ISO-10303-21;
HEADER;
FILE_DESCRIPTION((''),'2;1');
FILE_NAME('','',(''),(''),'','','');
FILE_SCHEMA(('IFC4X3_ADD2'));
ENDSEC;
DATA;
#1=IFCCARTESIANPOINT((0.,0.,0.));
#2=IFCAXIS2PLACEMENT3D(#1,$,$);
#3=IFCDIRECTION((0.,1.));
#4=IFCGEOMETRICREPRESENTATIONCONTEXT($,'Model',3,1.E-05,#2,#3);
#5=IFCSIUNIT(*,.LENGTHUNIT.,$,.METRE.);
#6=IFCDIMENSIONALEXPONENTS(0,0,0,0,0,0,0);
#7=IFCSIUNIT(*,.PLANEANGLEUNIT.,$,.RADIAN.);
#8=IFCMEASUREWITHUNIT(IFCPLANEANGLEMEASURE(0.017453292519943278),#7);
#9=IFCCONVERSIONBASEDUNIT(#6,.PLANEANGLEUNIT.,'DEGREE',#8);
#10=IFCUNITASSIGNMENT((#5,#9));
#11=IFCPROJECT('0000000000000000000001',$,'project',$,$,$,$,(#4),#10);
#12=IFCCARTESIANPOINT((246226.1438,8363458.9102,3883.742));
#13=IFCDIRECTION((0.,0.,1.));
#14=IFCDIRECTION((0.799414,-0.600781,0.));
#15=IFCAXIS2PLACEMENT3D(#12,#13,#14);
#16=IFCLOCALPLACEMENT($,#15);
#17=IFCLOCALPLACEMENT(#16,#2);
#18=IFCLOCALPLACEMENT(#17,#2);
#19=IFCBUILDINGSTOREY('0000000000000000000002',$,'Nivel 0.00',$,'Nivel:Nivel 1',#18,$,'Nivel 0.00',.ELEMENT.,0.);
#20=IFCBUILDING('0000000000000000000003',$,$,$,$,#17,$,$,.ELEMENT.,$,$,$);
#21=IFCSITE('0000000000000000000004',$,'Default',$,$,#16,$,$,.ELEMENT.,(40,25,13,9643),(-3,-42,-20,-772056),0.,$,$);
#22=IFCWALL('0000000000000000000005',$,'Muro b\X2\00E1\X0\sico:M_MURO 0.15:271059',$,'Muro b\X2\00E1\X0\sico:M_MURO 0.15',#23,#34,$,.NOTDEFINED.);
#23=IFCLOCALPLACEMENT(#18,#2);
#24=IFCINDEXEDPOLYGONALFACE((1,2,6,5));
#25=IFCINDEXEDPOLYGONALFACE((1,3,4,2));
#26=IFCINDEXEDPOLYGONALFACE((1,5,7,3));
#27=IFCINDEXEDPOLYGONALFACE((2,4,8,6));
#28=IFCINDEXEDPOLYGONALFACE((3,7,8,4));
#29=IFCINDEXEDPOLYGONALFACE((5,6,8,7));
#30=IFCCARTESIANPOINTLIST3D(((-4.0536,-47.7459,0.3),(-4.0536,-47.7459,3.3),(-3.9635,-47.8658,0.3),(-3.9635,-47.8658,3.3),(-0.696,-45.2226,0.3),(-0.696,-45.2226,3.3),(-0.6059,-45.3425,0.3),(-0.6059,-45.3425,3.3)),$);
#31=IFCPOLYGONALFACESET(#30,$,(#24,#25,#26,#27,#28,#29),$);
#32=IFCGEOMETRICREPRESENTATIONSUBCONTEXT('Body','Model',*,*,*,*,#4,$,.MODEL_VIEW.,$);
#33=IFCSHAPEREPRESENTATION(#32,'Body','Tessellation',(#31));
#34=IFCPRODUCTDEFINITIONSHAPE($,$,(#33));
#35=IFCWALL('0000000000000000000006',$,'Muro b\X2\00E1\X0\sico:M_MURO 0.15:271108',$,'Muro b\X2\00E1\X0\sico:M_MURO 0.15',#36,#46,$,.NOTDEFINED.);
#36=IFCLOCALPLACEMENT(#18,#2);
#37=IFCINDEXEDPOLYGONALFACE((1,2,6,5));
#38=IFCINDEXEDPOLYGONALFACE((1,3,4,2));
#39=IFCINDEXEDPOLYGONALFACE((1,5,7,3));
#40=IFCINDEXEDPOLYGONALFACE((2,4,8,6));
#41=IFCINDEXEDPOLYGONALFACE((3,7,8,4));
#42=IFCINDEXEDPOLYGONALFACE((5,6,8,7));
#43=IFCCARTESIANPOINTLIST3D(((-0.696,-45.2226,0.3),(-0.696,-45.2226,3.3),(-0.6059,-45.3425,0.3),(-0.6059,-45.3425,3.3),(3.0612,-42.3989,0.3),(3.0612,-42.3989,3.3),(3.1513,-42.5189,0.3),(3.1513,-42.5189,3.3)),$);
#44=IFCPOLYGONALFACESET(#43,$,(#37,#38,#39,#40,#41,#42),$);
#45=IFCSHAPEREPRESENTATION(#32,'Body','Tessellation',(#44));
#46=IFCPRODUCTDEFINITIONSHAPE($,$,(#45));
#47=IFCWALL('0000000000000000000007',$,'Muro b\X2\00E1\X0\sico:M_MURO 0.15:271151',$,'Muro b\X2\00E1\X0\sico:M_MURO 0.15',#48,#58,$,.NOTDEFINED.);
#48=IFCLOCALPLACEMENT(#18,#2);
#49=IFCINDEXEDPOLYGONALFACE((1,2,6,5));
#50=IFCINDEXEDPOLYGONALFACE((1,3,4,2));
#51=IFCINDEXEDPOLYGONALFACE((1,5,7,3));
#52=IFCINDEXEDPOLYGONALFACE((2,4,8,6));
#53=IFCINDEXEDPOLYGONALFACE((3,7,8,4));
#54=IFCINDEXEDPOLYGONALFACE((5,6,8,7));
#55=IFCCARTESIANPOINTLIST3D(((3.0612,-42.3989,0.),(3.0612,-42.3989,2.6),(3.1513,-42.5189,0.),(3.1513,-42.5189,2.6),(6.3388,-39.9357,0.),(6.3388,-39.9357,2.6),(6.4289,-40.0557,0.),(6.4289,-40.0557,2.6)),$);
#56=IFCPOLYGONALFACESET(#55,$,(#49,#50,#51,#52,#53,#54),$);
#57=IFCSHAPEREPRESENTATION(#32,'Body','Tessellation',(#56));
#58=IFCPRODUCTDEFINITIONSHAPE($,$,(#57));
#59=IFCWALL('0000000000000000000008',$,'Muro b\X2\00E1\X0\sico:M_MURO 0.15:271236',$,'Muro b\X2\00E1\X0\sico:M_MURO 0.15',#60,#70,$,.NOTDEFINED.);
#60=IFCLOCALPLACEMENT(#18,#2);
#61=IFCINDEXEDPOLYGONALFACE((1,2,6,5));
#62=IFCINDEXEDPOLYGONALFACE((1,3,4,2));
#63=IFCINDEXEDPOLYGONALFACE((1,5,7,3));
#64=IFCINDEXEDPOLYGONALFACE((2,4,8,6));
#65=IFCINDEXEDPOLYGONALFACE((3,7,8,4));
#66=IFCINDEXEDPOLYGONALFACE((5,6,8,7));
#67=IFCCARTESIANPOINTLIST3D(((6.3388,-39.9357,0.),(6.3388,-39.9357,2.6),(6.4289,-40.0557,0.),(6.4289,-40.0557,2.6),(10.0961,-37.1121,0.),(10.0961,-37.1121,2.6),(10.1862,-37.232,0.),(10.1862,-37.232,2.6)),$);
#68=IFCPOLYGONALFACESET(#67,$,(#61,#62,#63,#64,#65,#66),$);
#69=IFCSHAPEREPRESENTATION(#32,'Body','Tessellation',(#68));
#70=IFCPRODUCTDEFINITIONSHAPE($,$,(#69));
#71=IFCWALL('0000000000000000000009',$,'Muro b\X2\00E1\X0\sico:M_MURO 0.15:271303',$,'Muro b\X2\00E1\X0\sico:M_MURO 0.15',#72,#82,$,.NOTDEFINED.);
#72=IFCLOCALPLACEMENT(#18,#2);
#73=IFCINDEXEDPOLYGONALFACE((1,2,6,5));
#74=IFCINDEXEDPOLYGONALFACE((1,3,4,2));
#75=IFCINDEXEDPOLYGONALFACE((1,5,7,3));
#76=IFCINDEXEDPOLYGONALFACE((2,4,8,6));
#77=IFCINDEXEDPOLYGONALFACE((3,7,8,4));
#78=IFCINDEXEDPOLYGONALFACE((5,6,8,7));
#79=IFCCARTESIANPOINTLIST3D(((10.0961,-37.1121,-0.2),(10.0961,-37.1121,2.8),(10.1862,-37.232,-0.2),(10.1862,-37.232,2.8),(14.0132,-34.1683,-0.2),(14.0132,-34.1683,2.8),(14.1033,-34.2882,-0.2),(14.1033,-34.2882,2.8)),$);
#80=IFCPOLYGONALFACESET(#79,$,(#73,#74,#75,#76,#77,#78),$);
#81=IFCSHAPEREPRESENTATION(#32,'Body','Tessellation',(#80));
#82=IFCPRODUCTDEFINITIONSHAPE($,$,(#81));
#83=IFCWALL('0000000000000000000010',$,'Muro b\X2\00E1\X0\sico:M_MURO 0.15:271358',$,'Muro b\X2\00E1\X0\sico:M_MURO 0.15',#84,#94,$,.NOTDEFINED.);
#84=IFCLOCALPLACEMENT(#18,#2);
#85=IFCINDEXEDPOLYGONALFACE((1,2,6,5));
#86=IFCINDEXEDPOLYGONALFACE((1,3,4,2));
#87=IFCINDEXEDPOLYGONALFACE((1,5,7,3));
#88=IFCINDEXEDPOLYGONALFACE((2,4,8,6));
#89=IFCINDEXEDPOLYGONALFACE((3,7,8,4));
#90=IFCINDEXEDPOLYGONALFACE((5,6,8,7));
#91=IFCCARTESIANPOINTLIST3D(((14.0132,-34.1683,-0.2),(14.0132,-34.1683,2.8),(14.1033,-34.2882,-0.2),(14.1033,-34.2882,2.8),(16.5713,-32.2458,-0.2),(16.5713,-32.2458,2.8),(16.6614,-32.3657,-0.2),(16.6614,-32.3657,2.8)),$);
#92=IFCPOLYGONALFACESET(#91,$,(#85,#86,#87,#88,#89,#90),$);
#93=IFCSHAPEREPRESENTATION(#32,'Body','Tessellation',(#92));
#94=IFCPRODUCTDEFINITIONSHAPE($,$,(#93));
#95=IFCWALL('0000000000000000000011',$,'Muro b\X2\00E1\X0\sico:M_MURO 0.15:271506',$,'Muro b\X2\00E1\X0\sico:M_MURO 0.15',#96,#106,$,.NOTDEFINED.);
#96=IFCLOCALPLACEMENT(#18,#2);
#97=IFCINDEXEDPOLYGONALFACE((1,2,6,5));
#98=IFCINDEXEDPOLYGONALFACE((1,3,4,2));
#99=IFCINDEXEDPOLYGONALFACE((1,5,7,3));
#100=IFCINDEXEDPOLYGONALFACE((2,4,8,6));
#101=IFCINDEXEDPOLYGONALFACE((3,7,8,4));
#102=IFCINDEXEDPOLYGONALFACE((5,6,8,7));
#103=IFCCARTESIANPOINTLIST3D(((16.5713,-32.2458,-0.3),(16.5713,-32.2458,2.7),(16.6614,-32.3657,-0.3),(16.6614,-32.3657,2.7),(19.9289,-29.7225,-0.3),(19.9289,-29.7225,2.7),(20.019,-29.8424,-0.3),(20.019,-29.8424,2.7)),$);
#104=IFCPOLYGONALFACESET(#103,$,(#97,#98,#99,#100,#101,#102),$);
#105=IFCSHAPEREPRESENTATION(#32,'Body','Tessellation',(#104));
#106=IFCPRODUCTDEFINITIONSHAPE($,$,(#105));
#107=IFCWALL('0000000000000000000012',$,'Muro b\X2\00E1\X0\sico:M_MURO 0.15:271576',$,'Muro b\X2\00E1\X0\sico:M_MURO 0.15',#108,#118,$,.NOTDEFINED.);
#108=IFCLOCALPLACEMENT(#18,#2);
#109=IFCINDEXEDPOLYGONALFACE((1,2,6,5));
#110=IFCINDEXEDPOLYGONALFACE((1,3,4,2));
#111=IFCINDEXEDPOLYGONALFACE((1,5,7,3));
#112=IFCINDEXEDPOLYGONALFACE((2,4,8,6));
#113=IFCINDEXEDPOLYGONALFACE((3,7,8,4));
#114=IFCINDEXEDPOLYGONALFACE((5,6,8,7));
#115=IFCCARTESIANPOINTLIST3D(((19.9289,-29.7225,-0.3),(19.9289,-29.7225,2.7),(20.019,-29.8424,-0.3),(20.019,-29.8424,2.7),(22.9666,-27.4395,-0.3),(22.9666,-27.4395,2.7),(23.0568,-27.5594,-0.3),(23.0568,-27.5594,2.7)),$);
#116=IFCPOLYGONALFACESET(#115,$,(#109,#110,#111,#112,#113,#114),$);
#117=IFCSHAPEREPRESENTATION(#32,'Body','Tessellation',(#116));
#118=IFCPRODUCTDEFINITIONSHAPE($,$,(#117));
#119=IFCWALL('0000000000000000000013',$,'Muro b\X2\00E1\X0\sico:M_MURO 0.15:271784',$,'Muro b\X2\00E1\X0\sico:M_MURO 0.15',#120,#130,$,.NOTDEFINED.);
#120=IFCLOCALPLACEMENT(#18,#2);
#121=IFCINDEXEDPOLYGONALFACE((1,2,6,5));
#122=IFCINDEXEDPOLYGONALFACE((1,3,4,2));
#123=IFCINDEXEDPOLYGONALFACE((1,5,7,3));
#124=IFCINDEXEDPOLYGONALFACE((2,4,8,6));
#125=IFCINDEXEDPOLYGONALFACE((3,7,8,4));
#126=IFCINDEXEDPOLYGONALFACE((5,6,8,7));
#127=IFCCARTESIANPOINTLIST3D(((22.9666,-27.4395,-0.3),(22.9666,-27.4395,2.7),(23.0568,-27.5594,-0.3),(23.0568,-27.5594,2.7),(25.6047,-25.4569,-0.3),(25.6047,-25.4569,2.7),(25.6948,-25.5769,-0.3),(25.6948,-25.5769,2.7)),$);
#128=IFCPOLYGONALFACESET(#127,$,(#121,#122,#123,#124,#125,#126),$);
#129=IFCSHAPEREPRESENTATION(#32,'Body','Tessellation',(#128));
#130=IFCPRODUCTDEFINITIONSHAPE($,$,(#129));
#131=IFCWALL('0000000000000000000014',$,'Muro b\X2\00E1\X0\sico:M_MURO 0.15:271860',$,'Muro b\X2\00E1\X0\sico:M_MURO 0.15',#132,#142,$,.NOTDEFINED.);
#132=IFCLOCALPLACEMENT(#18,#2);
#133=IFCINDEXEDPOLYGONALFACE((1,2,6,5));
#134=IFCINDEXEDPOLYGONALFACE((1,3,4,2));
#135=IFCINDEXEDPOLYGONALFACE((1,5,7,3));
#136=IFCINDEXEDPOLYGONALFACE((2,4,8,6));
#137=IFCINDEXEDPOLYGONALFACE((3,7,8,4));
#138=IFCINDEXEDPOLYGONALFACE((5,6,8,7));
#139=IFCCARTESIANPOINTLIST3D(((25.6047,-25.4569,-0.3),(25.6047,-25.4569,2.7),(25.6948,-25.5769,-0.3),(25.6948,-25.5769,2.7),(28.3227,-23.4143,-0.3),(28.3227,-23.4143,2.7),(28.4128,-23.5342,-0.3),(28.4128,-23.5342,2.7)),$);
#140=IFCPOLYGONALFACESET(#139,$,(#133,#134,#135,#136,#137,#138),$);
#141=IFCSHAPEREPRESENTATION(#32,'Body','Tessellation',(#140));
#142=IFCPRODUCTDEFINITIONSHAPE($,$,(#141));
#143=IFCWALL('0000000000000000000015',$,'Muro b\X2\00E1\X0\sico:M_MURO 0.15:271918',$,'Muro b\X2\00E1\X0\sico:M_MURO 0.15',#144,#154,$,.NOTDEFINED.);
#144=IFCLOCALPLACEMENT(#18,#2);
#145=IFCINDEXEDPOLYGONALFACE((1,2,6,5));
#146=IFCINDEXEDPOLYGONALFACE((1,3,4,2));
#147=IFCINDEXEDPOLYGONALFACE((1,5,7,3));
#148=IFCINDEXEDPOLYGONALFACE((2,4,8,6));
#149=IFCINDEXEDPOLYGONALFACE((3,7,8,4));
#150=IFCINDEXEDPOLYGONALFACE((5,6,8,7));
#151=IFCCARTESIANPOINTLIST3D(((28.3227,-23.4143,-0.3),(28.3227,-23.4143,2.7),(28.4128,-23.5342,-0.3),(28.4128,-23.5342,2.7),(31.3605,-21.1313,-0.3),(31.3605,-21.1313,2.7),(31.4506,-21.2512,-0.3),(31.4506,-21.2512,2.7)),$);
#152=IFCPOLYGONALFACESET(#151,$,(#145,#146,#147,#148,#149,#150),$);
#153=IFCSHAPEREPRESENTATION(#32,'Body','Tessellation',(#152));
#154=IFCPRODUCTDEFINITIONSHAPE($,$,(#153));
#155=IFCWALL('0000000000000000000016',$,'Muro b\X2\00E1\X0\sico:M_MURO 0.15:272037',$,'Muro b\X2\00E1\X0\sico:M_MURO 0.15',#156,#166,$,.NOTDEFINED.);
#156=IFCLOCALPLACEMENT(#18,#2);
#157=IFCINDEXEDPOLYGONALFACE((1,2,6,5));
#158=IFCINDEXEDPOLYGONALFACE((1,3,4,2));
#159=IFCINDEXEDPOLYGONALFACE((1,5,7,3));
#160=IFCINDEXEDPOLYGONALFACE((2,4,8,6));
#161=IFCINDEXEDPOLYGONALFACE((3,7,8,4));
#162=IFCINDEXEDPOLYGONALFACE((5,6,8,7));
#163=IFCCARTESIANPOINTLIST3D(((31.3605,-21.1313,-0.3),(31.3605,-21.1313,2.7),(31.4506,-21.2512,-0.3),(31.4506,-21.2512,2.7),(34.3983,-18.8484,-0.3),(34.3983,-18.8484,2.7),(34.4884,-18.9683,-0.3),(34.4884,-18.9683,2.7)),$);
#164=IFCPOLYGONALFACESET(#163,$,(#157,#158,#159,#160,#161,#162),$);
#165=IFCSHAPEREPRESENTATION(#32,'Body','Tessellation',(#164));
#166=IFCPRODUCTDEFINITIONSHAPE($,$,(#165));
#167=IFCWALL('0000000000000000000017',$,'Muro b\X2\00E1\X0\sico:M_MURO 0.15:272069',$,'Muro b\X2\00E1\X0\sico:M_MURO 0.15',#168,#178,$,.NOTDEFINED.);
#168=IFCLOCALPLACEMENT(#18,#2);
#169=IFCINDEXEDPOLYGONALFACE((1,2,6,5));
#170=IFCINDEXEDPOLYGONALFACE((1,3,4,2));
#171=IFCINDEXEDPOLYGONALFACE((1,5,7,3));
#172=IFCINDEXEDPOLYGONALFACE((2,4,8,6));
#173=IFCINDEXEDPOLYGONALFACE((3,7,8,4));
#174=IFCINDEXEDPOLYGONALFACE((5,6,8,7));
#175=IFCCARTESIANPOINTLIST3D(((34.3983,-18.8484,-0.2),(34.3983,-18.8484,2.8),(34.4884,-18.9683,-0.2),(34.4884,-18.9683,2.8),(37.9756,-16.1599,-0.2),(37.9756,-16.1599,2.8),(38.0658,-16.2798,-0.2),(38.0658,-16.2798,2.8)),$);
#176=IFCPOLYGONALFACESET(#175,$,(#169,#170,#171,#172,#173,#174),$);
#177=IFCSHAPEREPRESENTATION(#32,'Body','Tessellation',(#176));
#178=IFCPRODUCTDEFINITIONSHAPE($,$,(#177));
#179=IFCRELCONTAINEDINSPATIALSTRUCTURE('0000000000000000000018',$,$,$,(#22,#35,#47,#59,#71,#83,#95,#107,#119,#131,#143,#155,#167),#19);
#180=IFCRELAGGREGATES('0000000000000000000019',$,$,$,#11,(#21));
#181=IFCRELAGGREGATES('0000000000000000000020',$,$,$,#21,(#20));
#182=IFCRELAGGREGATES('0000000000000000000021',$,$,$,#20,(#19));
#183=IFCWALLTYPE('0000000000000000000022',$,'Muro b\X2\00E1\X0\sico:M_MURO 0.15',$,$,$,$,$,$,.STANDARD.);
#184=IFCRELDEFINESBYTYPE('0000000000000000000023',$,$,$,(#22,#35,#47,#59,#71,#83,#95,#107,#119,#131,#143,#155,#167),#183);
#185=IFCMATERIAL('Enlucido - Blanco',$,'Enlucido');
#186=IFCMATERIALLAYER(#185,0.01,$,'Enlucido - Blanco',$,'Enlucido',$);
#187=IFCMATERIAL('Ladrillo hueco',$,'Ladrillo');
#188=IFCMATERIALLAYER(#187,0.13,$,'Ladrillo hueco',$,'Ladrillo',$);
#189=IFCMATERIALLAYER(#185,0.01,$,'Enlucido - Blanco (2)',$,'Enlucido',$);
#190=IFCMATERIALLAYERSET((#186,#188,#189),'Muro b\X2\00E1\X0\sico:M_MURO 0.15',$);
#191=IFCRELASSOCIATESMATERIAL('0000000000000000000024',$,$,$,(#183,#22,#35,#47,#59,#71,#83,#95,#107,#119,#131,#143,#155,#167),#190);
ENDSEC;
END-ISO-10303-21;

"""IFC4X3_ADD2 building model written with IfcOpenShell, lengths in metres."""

from ifc_helpers import new_model, entity, si_unit, converted_unit, direction, frame, frame_2d, origin, place, context, subcontext, project, spatial, rectangle, extrude, material, layer, layer_set, type_object, element, save


model = new_model("IFC4X3_ADD2")

# Units and contexts
model_context = context("Model", 3, precision=1e-05, world=origin(), true_north=direction((0.0, 1.0)))
body_context = subcontext(model_context, "Body", "Model", "MODEL_VIEW")
ifc_project = project(units=[si_unit("LENGTHUNIT", "METRE"), converted_unit("PLANEANGLEUNIT", "DEGREE", entity("IfcPlaneAngleMeasure", 0.017453292519943278), si_unit("PLANEANGLEUNIT", "RADIAN"), dimensions=[0, 0, 0, 0, 0, 0, 0])], contexts=[model_context])

# Site, building, storey
site_placement = place(None, frame((246226.1438, 8363458.9102, 3883.742), z_axis=(0.0, 0.0, 1.0), x_axis=(0.799414, -0.600781, 0.0)))
site = spatial("IfcSite", under=ifc_project, at=site_placement, Name="Default", CompositionType="ELEMENT", RefLatitude=(40, 25, 13, 9643), RefLongitude=(-3, -42, -20, -772056), RefElevation=0.0)
building_placement = place(site_placement, origin())
building = spatial("IfcBuilding", under=site, at=building_placement, CompositionType="ELEMENT")
storey_placement = place(building_placement, origin())
storey = spatial("IfcBuildingStorey", under=building, at=storey_placement, Name="Nivel 0.00", ObjectType="Nivel:Nivel 1", LongName="Nivel 0.00", CompositionType="ELEMENT", Elevation=0.0)

# Walls
ifc_material_1 = material(Name="Enlucido - Blanco", Category="Enlucido")
ifc_layer_1 = layer(ifc_material_1, 0.01, Name="Enlucido - Blanco", Category="Enlucido")
ifc_material_2 = material(Name="Ladrillo hueco", Category="Ladrillo")
ifc_layer_2 = layer(ifc_material_2, 0.13, Name="Ladrillo hueco", Category="Ladrillo")
ifc_layer_3 = layer(ifc_material_1, 0.01, Name="Enlucido - Blanco (2)", Category="Enlucido")
ifc_layer_set_1 = layer_set([ifc_layer_1, ifc_layer_2, ifc_layer_3], Name="Muro básico:M_MURO 0.15")
wall_type = type_object("IfcWallType", Name="Muro básico:M_MURO 0.15", PredefinedType="STANDARD", material=ifc_layer_set_1)
wall_1_placement = place(storey_placement, frame((-0.651, -45.2826, 0.3), z_axis=(0.0, 0.0, 1.0), x_axis=(-0.799414, -0.60078, 0.0)))
element("IfcWall", 1, at=wall_1_placement, inside=storey, type_object=wall_type, material=ifc_layer_set_1, Name="Muro básico:M_MURO 0.15:271059", ObjectType="Muro básico:M_MURO 0.15", PredefinedType="NOTDEFINED", context=body_context, shape_type="SweptSolid", body=[
    extrude(rectangle(XDim=4.2, YDim=0.15, at=frame_2d((2.1, 0.0), x_axis=(-1.0, 0.0))), origin(), (0.0, 0.0, 1.0), 3.0),
])
wall_2_placement = place(storey_placement, frame((3.1063, -42.4589, 0.3), z_axis=(0.0, 0.0, 1.0), x_axis=(-0.799414, -0.60078, 0.0)))
element("IfcWall", 2, at=wall_2_placement, inside=storey, type_object=wall_type, material=ifc_layer_set_1, Name="Muro básico:M_MURO 0.15:271108", ObjectType="Muro básico:M_MURO 0.15", PredefinedType="NOTDEFINED", context=body_context, shape_type="SweptSolid", body=[
    extrude(rectangle(XDim=4.7, YDim=0.15, at=frame_2d((2.35, 0.0), x_axis=(-1.0, 0.0))), origin(), (0.0, 0.0, 1.0), 3.0),
])
wall_3_placement = place(storey_placement, frame((6.3839, -39.9957, 0.0), z_axis=(0.0, 0.0, 1.0), x_axis=(-0.799414, -0.60078, 0.0)))
element("IfcWall", 3, at=wall_3_placement, inside=storey, type_object=wall_type, material=ifc_layer_set_1, Name="Muro básico:M_MURO 0.15:271151", ObjectType="Muro básico:M_MURO 0.15", PredefinedType="NOTDEFINED", context=body_context, shape_type="SweptSolid", body=[
    extrude(rectangle(XDim=4.1, YDim=0.15, at=frame_2d((2.05, 0.0), x_axis=(-1.0, 0.0))), origin(), (0.0, 0.0, 1.0), 2.6),
])
wall_4_placement = place(storey_placement, frame((10.1411, -37.172, 0.0), z_axis=(0.0, 0.0, 1.0), x_axis=(-0.799414, -0.60078, 0.0)))
element("IfcWall", 4, at=wall_4_placement, inside=storey, type_object=wall_type, material=ifc_layer_set_1, Name="Muro básico:M_MURO 0.15:271236", ObjectType="Muro básico:M_MURO 0.15", PredefinedType="NOTDEFINED", context=body_context, shape_type="SweptSolid", body=[
    extrude(rectangle(XDim=4.7, YDim=0.15, at=frame_2d((2.35, 0.0), x_axis=(-1.0, 0.0))), origin(), (0.0, 0.0, 1.0), 2.6),
])
wall_5_placement = place(storey_placement, frame((14.0583, -34.2282, -0.2), z_axis=(0.0, 0.0, 1.0), x_axis=(-0.799414, -0.60078, 0.0)))
element("IfcWall", 5, at=wall_5_placement, inside=storey, type_object=wall_type, material=ifc_layer_set_1, Name="Muro básico:M_MURO 0.15:271303", ObjectType="Muro básico:M_MURO 0.15", PredefinedType="NOTDEFINED", context=body_context, shape_type="SweptSolid", body=[
    extrude(rectangle(XDim=4.9, YDim=0.15, at=frame_2d((2.45, 0.0), x_axis=(-1.0, 0.0))), origin(), (0.0, 0.0, 1.0), 3.0),
])
wall_6_placement = place(storey_placement, frame((16.6164, -32.3057, -0.2), z_axis=(0.0, 0.0, 1.0), x_axis=(-0.799414, -0.60078, 0.0)))
element("IfcWall", 6, at=wall_6_placement, inside=storey, type_object=wall_type, material=ifc_layer_set_1, Name="Muro básico:M_MURO 0.15:271358", ObjectType="Muro básico:M_MURO 0.15", PredefinedType="NOTDEFINED", context=body_context, shape_type="SweptSolid", body=[
    extrude(rectangle(XDim=3.2, YDim=0.15, at=frame_2d((1.6, 0.0), x_axis=(-1.0, 0.0))), origin(), (0.0, 0.0, 1.0), 3.0),
])
wall_7_placement = place(storey_placement, frame((19.9739, -29.7824, -0.3), z_axis=(0.0, 0.0, 1.0), x_axis=(-0.799414, -0.60078, 0.0)))
element("IfcWall", 7, at=wall_7_placement, inside=storey, type_object=wall_type, material=ifc_layer_set_1, Name="Muro básico:M_MURO 0.15:271506", ObjectType="Muro básico:M_MURO 0.15", PredefinedType="NOTDEFINED", context=body_context, shape_type="SweptSolid", body=[
    extrude(rectangle(XDim=4.2, YDim=0.15, at=frame_2d((2.1, 0.0), x_axis=(-1.0, 0.0))), origin(), (0.0, 0.0, 1.0), 3.0),
])
wall_8_placement = place(storey_placement, frame((23.0117, -27.4995, -0.3), z_axis=(0.0, 0.0, 1.0), x_axis=(-0.799414, -0.60078, 0.0)))
element("IfcWall", 8, at=wall_8_placement, inside=storey, type_object=wall_type, material=ifc_layer_set_1, Name="Muro básico:M_MURO 0.15:271576", ObjectType="Muro básico:M_MURO 0.15", PredefinedType="NOTDEFINED", context=body_context, shape_type="SweptSolid", body=[
    extrude(rectangle(XDim=3.8, YDim=0.15, at=frame_2d((1.9, 0.0), x_axis=(-1.0, 0.0))), origin(), (0.0, 0.0, 1.0), 3.0),
])
wall_9_placement = place(storey_placement, frame((25.6498, -25.5169, -0.3), z_axis=(0.0, 0.0, 1.0), x_axis=(-0.799414, -0.60078, 0.0)))
element("IfcWall", 9, at=wall_9_placement, inside=storey, type_object=wall_type, material=ifc_layer_set_1, Name="Muro básico:M_MURO 0.15:271784", ObjectType="Muro básico:M_MURO 0.15", PredefinedType="NOTDEFINED", context=body_context, shape_type="SweptSolid", body=[
    extrude(rectangle(XDim=3.3, YDim=0.15, at=frame_2d((1.65, 0.0), x_axis=(-1.0, 0.0))), origin(), (0.0, 0.0, 1.0), 3.0),
])
wall_10_placement = place(storey_placement, frame((28.3678, -23.4743, -0.3), z_axis=(0.0, 0.0, 1.0), x_axis=(-0.799414, -0.60078, 0.0)))
element("IfcWall", 10, at=wall_10_placement, inside=storey, type_object=wall_type, material=ifc_layer_set_1, Name="Muro básico:M_MURO 0.15:271860", ObjectType="Muro básico:M_MURO 0.15", PredefinedType="NOTDEFINED", context=body_context, shape_type="SweptSolid", body=[
    extrude(rectangle(XDim=3.4, YDim=0.15, at=frame_2d((1.7, 0.0), x_axis=(-1.0, 0.0))), origin(), (0.0, 0.0, 1.0), 3.0),
])
wall_11_placement = place(storey_placement, frame((31.4055, -21.1913, -0.3), z_axis=(0.0, 0.0, 1.0), x_axis=(-0.799414, -0.60078, 0.0)))
element("IfcWall", 11, at=wall_11_placement, inside=storey, type_object=wall_type, material=ifc_layer_set_1, Name="Muro básico:M_MURO 0.15:271918", ObjectType="Muro básico:M_MURO 0.15", PredefinedType="NOTDEFINED", context=body_context, shape_type="SweptSolid", body=[
    extrude(rectangle(XDim=3.8, YDim=0.15, at=frame_2d((1.9, 0.0), x_axis=(-1.0, 0.0))), origin(), (0.0, 0.0, 1.0), 3.0),
])
wall_12_placement = place(storey_placement, frame((34.4433, -18.9083, -0.3), z_axis=(0.0, 0.0, 1.0), x_axis=(-0.799414, -0.60078, 0.0)))
element("IfcWall", 12, at=wall_12_placement, inside=storey, type_object=wall_type, material=ifc_layer_set_1, Name="Muro básico:M_MURO 0.15:272037", ObjectType="Muro básico:M_MURO 0.15", PredefinedType="NOTDEFINED", context=body_context, shape_type="SweptSolid", body=[
    extrude(rectangle(XDim=3.8, YDim=0.15, at=frame_2d((1.9, 0.0), x_axis=(-1.0, 0.0))), origin(), (0.0, 0.0, 1.0), 3.0),
])
wall_13_placement = place(storey_placement, frame((38.0207, -16.2198, -0.2), z_axis=(0.0, 0.0, 1.0), x_axis=(-0.799414, -0.60078, 0.0)))
element("IfcWall", 13, at=wall_13_placement, inside=storey, type_object=wall_type, material=ifc_layer_set_1, Name="Muro básico:M_MURO 0.15:272069", ObjectType="Muro básico:M_MURO 0.15", PredefinedType="NOTDEFINED", context=body_context, shape_type="SweptSolid", body=[
    extrude(rectangle(XDim=4.475, YDim=0.15, at=frame_2d((2.2375, 0.0), x_axis=(-1.0, 0.0))), origin(), (0.0, 0.0, 1.0), 3.0),
])

save(model, "model.ifc")
